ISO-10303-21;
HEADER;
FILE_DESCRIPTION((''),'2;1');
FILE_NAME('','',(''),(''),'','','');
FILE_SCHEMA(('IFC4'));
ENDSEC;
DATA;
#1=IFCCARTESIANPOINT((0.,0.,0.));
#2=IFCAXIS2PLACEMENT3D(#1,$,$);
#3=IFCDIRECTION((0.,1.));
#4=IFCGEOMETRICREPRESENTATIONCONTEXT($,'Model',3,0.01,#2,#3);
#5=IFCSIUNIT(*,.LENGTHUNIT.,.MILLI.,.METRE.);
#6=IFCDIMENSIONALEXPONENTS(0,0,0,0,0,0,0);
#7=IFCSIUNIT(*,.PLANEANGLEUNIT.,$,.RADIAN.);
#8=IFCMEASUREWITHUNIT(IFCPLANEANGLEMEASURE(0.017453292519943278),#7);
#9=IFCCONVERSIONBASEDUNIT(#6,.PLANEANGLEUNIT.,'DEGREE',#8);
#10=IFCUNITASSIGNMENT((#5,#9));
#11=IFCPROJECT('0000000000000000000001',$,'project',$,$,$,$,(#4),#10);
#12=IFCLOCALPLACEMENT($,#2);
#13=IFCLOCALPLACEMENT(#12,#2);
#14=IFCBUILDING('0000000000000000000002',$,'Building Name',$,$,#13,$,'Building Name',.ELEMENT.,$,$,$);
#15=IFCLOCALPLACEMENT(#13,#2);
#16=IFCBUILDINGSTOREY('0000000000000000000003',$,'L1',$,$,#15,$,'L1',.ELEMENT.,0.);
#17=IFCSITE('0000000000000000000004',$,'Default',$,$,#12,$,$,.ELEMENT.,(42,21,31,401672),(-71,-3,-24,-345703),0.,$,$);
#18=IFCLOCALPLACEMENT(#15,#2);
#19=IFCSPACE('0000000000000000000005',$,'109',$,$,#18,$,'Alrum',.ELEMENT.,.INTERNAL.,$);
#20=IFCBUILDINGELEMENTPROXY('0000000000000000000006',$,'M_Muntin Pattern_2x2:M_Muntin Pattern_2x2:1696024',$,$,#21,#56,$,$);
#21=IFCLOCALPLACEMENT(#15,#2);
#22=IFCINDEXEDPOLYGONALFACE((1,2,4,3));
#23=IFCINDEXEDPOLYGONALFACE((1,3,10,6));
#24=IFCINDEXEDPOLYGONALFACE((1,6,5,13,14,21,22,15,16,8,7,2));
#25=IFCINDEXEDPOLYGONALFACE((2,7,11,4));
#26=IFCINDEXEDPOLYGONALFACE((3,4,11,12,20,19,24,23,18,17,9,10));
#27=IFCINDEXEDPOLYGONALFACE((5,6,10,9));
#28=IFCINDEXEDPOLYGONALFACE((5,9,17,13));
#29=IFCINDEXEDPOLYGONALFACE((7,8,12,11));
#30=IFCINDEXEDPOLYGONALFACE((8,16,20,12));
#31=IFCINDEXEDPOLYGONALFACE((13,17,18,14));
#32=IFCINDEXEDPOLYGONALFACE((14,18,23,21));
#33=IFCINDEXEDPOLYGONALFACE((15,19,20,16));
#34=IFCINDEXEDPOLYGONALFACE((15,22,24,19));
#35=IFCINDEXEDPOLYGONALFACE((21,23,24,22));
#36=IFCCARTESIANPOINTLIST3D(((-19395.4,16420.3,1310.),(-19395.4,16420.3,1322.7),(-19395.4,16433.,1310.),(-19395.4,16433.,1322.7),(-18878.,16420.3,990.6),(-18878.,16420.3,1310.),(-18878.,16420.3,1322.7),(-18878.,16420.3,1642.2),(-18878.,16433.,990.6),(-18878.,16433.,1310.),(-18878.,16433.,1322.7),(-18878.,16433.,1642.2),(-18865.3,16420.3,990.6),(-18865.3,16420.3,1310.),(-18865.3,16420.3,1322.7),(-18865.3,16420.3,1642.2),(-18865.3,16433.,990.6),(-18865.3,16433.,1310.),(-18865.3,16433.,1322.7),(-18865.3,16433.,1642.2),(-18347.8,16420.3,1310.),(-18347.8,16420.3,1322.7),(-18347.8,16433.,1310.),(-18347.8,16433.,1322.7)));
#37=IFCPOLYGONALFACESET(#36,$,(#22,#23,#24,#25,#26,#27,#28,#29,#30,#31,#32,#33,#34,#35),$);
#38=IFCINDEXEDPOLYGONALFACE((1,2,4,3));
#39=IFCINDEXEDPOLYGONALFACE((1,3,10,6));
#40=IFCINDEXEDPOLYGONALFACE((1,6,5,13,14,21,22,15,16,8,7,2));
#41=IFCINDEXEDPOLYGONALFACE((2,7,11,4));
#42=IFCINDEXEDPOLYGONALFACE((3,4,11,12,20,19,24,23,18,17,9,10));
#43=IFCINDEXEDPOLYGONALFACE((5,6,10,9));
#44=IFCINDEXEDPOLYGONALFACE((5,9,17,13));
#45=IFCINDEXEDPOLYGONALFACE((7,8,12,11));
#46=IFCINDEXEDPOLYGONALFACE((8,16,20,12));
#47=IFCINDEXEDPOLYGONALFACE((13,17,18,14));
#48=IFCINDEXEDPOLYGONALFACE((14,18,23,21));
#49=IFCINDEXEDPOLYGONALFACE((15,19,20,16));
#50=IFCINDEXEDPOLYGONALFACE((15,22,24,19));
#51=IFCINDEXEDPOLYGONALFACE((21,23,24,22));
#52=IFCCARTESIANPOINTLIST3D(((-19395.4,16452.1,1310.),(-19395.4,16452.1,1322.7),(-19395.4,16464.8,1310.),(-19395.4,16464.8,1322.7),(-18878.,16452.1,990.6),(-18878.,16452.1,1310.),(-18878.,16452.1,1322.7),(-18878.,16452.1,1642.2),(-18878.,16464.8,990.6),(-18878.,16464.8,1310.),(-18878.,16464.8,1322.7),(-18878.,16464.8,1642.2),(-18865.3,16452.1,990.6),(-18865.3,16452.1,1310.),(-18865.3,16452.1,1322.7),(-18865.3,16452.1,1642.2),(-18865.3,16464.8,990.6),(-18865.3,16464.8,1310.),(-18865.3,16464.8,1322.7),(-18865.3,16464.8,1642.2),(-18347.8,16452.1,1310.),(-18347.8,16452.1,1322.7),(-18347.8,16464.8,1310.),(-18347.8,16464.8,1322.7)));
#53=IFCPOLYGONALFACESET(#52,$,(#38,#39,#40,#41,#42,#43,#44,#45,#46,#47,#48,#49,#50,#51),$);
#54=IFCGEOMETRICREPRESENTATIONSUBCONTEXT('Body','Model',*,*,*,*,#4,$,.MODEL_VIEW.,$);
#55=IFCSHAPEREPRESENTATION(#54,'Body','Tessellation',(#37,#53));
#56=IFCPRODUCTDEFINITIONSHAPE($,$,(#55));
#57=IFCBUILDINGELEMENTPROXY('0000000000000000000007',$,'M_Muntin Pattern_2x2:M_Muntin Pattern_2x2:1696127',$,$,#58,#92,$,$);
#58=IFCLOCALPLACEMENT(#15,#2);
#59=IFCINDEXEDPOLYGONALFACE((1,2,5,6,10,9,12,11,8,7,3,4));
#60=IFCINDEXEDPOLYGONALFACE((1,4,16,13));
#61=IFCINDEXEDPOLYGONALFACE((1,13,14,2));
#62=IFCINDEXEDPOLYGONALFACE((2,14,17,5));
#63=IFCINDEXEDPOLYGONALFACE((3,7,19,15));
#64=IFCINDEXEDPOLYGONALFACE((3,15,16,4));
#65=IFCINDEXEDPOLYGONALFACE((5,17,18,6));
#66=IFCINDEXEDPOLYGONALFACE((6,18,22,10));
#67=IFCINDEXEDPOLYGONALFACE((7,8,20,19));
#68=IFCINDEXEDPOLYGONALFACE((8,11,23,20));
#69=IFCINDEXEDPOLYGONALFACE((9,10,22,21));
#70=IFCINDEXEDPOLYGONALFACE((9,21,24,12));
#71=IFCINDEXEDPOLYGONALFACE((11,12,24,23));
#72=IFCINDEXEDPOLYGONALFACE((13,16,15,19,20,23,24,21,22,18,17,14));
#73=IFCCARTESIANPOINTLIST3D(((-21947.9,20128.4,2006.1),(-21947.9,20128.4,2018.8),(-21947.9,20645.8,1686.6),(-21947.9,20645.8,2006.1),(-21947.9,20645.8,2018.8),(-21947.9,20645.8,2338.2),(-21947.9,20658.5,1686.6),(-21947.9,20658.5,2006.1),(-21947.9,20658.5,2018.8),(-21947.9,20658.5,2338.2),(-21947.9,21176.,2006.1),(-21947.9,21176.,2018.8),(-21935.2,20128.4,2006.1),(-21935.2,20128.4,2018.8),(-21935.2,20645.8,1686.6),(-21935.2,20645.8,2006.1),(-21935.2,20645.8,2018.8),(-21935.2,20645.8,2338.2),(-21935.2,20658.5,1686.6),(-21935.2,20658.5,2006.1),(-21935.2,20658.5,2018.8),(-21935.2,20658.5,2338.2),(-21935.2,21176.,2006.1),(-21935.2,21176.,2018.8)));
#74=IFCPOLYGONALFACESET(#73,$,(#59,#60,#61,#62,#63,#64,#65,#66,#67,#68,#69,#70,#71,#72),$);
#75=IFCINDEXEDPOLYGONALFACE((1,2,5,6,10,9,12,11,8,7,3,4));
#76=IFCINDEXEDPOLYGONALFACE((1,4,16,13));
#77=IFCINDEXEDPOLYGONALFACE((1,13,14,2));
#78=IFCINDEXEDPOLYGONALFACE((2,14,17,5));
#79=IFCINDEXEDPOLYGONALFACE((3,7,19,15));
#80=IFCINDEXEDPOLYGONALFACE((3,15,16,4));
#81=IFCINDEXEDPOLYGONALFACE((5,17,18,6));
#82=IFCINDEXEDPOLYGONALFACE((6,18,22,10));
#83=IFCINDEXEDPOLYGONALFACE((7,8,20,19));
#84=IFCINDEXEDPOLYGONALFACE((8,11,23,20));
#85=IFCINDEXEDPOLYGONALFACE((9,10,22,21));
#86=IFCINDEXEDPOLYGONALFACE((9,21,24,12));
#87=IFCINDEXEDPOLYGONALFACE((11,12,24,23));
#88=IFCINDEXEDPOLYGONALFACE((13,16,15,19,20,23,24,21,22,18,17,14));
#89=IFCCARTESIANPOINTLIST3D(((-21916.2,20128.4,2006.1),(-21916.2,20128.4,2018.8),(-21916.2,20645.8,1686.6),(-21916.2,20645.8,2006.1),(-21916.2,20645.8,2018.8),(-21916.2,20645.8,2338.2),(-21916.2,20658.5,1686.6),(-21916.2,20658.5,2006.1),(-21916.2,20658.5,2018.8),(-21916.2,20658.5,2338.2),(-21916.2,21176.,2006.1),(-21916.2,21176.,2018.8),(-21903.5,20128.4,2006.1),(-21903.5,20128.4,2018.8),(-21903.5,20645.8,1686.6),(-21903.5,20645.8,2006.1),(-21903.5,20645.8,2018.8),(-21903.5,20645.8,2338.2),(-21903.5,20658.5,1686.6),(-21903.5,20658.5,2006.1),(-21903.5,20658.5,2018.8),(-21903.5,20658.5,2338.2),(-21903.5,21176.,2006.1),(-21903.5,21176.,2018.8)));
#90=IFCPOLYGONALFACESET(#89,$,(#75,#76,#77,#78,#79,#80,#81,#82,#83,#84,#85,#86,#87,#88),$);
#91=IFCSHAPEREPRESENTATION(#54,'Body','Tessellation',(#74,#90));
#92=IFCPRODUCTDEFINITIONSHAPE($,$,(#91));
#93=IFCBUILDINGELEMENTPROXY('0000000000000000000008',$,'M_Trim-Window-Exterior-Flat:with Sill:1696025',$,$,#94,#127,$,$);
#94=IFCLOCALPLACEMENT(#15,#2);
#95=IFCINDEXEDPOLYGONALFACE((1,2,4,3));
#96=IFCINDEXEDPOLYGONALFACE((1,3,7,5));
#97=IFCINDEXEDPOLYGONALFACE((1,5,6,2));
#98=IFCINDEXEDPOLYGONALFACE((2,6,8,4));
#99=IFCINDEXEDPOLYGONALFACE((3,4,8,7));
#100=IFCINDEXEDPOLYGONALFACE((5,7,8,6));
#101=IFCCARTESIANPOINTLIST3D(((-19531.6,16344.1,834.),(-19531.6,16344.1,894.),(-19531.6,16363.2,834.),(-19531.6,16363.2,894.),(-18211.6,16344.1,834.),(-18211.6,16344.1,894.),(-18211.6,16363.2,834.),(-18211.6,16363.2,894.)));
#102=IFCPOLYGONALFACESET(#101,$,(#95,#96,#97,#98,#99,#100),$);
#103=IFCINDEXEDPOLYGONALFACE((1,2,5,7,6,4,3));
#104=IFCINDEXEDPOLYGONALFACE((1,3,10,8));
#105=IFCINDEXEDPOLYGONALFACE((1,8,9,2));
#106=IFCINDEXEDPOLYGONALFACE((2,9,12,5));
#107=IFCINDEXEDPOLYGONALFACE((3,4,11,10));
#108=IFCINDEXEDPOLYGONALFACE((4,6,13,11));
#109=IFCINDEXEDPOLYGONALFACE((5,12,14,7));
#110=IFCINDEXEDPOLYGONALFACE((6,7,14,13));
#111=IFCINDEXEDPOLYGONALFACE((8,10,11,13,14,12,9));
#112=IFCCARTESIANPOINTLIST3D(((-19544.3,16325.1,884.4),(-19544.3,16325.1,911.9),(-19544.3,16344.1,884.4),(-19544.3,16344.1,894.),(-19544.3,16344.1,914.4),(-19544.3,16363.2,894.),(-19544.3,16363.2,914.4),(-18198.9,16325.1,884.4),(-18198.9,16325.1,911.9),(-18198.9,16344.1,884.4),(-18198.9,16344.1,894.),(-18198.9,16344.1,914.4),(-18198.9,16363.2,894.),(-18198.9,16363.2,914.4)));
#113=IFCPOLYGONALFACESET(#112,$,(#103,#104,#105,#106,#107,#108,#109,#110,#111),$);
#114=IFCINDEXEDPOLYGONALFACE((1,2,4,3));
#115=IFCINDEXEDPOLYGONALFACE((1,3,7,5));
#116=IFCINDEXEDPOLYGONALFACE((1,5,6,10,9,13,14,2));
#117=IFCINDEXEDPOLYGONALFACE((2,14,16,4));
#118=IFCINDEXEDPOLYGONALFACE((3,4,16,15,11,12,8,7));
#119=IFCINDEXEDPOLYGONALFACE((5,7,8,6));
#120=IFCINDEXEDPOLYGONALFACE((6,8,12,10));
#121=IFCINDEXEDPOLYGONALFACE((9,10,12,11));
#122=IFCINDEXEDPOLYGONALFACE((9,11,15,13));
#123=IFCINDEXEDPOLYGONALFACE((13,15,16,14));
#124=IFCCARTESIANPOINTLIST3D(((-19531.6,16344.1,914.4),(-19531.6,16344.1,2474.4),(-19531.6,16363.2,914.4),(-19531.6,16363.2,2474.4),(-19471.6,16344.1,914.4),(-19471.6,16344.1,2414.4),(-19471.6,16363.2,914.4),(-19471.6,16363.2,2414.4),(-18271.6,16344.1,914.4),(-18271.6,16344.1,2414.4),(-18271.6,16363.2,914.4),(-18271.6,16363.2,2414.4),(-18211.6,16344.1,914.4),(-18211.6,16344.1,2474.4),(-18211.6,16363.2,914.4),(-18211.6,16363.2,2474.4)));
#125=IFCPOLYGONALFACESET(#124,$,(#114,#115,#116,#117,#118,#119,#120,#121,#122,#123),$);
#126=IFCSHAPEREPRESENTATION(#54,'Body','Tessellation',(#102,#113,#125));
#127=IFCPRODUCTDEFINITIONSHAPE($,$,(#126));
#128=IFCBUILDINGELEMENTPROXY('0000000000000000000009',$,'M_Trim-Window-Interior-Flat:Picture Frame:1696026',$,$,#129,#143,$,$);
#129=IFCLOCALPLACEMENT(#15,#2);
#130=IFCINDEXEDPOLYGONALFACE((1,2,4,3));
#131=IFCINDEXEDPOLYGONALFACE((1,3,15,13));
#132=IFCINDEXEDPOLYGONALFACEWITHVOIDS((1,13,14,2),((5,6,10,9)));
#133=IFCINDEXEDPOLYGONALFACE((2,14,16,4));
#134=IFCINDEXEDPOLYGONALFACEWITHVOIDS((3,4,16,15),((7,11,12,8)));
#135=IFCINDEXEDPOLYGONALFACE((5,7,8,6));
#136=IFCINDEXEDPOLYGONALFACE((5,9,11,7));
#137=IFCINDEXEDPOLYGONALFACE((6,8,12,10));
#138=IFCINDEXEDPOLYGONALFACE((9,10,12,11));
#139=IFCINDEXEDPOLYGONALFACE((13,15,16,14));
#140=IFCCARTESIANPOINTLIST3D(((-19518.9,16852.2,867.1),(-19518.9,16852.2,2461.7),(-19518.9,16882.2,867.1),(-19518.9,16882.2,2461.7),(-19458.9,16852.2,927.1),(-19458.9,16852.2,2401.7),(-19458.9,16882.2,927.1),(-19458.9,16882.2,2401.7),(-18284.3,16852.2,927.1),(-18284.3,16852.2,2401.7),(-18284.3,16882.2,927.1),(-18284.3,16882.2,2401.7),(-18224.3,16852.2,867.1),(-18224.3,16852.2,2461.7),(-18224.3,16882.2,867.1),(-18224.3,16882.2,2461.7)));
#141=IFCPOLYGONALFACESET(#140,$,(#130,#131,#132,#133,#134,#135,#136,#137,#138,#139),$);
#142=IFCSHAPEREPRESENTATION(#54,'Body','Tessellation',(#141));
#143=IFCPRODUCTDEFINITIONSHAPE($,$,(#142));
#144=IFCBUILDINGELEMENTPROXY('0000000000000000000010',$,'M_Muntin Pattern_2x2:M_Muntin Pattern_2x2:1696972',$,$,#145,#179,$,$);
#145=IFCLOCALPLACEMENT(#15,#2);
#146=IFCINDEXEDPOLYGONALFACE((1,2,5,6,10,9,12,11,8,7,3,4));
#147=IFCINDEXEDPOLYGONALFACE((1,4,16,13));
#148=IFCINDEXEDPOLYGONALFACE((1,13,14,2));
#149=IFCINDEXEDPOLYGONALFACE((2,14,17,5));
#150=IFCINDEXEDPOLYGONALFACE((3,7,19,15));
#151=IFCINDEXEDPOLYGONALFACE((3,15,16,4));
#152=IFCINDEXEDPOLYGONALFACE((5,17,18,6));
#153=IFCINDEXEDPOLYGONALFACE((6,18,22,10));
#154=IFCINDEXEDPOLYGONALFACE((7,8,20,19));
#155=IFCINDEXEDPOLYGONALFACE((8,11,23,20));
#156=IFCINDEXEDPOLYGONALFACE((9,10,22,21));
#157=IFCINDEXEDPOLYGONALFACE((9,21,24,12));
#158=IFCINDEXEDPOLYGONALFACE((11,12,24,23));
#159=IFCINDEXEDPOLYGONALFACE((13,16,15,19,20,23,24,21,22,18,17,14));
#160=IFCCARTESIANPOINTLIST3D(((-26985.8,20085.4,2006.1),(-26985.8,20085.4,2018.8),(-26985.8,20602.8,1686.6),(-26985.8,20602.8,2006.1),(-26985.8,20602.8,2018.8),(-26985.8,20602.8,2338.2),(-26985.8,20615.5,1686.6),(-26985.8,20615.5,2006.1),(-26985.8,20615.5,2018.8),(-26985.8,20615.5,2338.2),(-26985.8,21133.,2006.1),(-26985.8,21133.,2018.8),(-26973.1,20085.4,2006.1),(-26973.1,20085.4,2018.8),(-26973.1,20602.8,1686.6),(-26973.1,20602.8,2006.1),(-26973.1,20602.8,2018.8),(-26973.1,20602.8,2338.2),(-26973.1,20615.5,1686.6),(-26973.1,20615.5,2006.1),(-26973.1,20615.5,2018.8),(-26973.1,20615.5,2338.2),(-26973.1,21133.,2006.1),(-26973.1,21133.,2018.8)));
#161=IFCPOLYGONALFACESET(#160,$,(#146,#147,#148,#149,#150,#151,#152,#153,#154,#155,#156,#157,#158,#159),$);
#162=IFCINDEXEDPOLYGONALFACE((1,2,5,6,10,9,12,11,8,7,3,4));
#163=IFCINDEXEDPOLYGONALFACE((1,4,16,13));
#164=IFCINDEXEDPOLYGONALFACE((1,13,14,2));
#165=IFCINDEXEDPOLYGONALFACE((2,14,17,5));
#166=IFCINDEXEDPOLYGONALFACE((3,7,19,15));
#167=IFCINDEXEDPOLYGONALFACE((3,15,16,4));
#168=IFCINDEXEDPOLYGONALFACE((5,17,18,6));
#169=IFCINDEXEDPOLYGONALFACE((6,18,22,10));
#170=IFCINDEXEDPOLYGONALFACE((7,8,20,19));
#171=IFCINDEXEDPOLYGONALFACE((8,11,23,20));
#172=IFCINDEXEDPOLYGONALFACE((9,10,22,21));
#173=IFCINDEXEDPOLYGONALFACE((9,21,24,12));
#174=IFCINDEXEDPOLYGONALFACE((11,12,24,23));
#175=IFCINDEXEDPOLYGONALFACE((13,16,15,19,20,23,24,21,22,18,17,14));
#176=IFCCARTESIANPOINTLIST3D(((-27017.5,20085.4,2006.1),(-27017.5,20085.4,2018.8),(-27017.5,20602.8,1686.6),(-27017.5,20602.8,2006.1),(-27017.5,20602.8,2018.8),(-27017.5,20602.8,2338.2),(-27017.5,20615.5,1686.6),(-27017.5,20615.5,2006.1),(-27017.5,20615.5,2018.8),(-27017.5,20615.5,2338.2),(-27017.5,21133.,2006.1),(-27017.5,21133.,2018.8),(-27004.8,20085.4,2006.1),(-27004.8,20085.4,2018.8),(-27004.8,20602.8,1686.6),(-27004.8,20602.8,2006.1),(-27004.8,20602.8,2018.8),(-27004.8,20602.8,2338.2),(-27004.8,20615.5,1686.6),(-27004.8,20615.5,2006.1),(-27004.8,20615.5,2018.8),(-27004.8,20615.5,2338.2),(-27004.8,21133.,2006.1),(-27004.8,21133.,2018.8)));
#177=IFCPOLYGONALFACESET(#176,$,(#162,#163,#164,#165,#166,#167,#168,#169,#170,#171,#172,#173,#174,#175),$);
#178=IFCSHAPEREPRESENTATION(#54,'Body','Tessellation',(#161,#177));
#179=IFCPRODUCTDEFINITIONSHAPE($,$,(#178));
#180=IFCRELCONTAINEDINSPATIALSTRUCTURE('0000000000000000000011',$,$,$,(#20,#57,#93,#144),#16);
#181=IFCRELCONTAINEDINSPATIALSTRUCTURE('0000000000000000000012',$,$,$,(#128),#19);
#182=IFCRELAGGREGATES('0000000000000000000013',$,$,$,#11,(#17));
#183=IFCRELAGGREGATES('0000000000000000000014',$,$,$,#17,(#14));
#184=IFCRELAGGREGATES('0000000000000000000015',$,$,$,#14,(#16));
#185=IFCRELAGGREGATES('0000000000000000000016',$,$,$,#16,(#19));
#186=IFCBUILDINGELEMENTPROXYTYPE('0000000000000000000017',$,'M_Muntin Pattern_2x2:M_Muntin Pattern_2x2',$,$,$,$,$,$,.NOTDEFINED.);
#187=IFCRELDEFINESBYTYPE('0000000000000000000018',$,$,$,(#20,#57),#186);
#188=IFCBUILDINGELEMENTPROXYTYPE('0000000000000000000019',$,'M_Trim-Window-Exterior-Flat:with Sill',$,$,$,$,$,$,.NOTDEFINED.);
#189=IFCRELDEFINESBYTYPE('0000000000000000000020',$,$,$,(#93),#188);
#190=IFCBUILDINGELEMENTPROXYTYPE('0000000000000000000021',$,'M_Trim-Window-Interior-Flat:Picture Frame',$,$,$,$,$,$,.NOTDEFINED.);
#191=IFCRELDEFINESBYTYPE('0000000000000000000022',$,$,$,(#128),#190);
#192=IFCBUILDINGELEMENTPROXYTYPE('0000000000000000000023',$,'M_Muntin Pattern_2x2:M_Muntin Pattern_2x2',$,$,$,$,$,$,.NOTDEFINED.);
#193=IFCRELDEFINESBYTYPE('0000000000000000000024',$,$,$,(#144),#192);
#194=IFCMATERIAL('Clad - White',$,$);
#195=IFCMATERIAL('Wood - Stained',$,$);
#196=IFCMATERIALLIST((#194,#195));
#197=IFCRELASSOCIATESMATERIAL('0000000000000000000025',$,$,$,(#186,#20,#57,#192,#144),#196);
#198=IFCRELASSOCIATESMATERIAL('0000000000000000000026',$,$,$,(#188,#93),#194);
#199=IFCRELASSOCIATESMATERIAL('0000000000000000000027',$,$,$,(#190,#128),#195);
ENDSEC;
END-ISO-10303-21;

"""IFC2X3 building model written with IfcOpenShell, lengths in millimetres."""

from ifc_helpers import new_model, entity, si_unit, converted_unit, direction, frame, frame_2d, origin, place, context, subcontext, project, spatial, polyline, rectangle, outline, extrude, source, transform, mapped, material, material_list, type_object, type_shapes, element, save


model = new_model("IFC2X3")

# Units and contexts
model_context = context("Model", 3, precision=0.01, world=origin(), true_north=direction((0.0, 1.0)))
body_context = subcontext(model_context, "Body", "Model", "MODEL_VIEW")
ifc_project = project(units=[si_unit("LENGTHUNIT", "METRE", prefix="MILLI"), converted_unit("PLANEANGLEUNIT", "DEGREE", entity("IfcPlaneAngleMeasure", 0.017453292519943278), si_unit("PLANEANGLEUNIT", "RADIAN"), dimensions=[0, 0, 0, 0, 0, 0, 0])], contexts=[model_context])

# Site, building, storey
site_placement = place(None, origin())
site = spatial("IfcSite", under=ifc_project, at=site_placement, Name="Default", CompositionType="ELEMENT", RefLatitude=(42, 21, 31, 401672), RefLongitude=(-71, -3, -24, -345703), RefElevation=0.0)
building_placement = place(site_placement, origin())
building = spatial("IfcBuilding", under=site, at=building_placement, Name="Building Name", LongName="Building Name", CompositionType="ELEMENT")
storey_placement = place(building_placement, origin())
storey = spatial("IfcBuildingStorey", under=building, at=storey_placement, Name="L1", LongName="L1", CompositionType="ELEMENT", Elevation=0.0)

# Shared definitions
ifc_material_1 = material(Name="Wood - Stained")

# Building element proxies
ifc_material_2 = material(Name="Clad - White")
ifc_material_list_1 = material_list([ifc_material_2, ifc_material_1])
building_element_proxy_type_1 = type_object("IfcBuildingElementProxyType", Name="M_Muntin Pattern_2x2:M_Muntin Pattern_2x2", PredefinedType="NOTDEFINED", material=ifc_material_list_1)
shared_shape_1 = source(origin(), body_context, "Body", "SweptSolid", [
    extrude(outline(polyline([(6.4, -6.4), (325.8, -6.4), (325.8, 6.3), (6.4, 6.3), (6.4, 523.8), (-6.3, 523.8), (-6.3, 6.3), (-325.8, 6.3), (-325.8, -6.4), (-6.3, -6.4), (-6.3, -523.8), (6.4, -523.8), (6.4, -6.4)])), frame((0.0, 9.5, 325.8), z_axis=(0.0, 1.0, 0.0), x_axis=(0.0, 0.0, 1.0)), (0.0, 0.0, 1.0), 12.7),
    extrude(outline(polyline([(6.4, -6.4), (325.8, -6.4), (325.8, 6.3), (6.4, 6.3), (6.4, 523.8), (-6.3, 523.8), (-6.3, 6.3), (-325.8, 6.3), (-325.8, -6.4), (-6.3, -6.4), (-6.3, -523.8), (6.4, -523.8), (6.4, -6.4)])), frame((0.0, -22.2, 325.8), z_axis=(0.0, 1.0, 0.0), x_axis=(0.0, 0.0, 1.0)), (0.0, 0.0, 1.0), 12.7),
])
type_shapes(building_element_proxy_type_1, [shared_shape_1])
for number, where, z_axis, x_axis, name in (
    (1, (-18871.6, 16442.5, 990.6), (0.0, 0.0, 1.0), (-1.0, 0.0, 0.0), "M_Muntin Pattern_2x2:M_Muntin Pattern_2x2:1696024"),
    (2, (-21925.7, 20652.2, 1686.6), (0.0, 0.0, 1.0), (0.0, 1.0, 0.0), "M_Muntin Pattern_2x2:M_Muntin Pattern_2x2:1696127"),
):
    element("IfcBuildingElementProxy", number, at=place(storey_placement, frame(where, z_axis=z_axis, x_axis=x_axis)), inside=storey, type_object=building_element_proxy_type_1, material=ifc_material_list_1, Name=name, context=body_context, shape_type="MappedRepresentation", body=[
        mapped(shared_shape_1, transform((0.0, 0.0, 0.0), scale=1.0)),
    ])
building_element_proxy_type_2 = type_object("IfcBuildingElementProxyType", Name="M_Trim-Window-Exterior-Flat:with Sill", PredefinedType="NOTDEFINED", material=ifc_material_2)
shared_shape_2 = source(origin(), body_context, "Body", "SweptSolid", [
    extrude(rectangle(XDim=1320.0, YDim=60.0, at=frame_2d((0.0, 0.0), x_axis=(1.0, 0.0))), frame((0.0, -1550.4, 0.0), z_axis=(0.0, 0.0, 1.0), x_axis=(-1.0, 0.0, 0.0)), (0.0, 0.0, 1.0), 19.0),
    extrude(outline(polyline([(-19.0, -15.2), (0.0, -15.2), (0.0, -5.7), (19.0, -5.7), (19.0, 14.8), (0.0, 14.8), (-19.0, 12.3), (-19.0, -15.2)])), frame((-672.7, -1514.8, 19.0), z_axis=(1.0, 0.0, 0.0), x_axis=(0.0, 0.0, -1.0)), (0.0, 0.0, 1.0), 1345.4),
    extrude(outline(polyline([(-795.0, -660.0), (765.0, -660.0), (765.0, -600.0), (-735.0, -600.0), (-735.0, 600.0), (765.0, 600.0), (765.0, 660.0), (-795.0, 660.0), (-795.0, -660.0)])), frame((0.0, -735.0, 0.0), z_axis=(0.0, 0.0, 1.0), x_axis=(0.0, -1.0, 0.0)), (0.0, 0.0, 1.0), 19.0),
])
type_shapes(building_element_proxy_type_2, [shared_shape_2])
proxy_1_placement = place(storey_placement, frame((-18871.6, 16363.2, 2414.4), z_axis=(0.0, -1.0, 0.0), x_axis=(1.0, 0.0, 0.0)))
element("IfcBuildingElementProxy", 3, at=proxy_1_placement, inside=storey, type_object=building_element_proxy_type_2, material=ifc_material_2, Name="M_Trim-Window-Exterior-Flat:with Sill:1696025", context=body_context, shape_type="MappedRepresentation", body=[
    mapped(shared_shape_2, transform((0.0, 0.0, 0.0), scale=1.0)),
])

# Shared definitions
space_placement = place(storey_placement, origin())
space = spatial("IfcSpace", under=storey, at=space_placement, Name="109", LongName="Alrum", CompositionType="ELEMENT", InteriorOrExteriorSpace="INTERNAL")

# Building element proxies
building_element_proxy_type_3 = type_object("IfcBuildingElementProxyType", Name="M_Trim-Window-Interior-Flat:Picture Frame", PredefinedType="NOTDEFINED", material=ifc_material_1)
shared_shape_3 = source(origin(), body_context, "Body", "SweptSolid", [
    extrude(outline(polyline([(-647.3, -797.3), (647.3, -797.3), (647.3, 797.3), (-647.3, 797.3), (-647.3, -797.3)]), holes=[polyline([(-587.3, -737.3), (-587.3, 737.3), (587.3, 737.3), (587.3, -737.3), (-587.3, -737.3)])]), frame((0.0, -750.0, 0.0), z_axis=(0.0, 0.0, 1.0), x_axis=(-1.0, 0.0, 0.0)), (0.0, 0.0, 1.0), 30.0),
])
type_shapes(building_element_proxy_type_3, [shared_shape_3])
proxy_2_placement = place(space_placement, frame((-18871.6, 16852.2, 2414.4), z_axis=(0.0, 1.0, 0.0), x_axis=(-1.0, 0.0, 0.0)))
element("IfcBuildingElementProxy", 4, at=proxy_2_placement, inside=space, type_object=building_element_proxy_type_3, material=ifc_material_1, Name="M_Trim-Window-Interior-Flat:Picture Frame:1696026", context=body_context, shape_type="MappedRepresentation", body=[
    mapped(shared_shape_3, transform((0.0, 0.0, 0.0), scale=1.0)),
])
building_element_proxy_type_4 = type_object("IfcBuildingElementProxyType", Name="M_Muntin Pattern_2x2:M_Muntin Pattern_2x2", PredefinedType="NOTDEFINED", material=ifc_material_list_1)
shared_shape_4 = source(origin(), body_context, "Body", "SweptSolid", [
    extrude(outline(polyline([(6.4, -6.4), (325.8, -6.4), (325.8, 6.3), (6.4, 6.3), (6.4, 523.8), (-6.3, 523.8), (-6.3, 6.3), (-325.8, 6.3), (-325.8, -6.4), (-6.3, -6.4), (-6.3, -523.8), (6.4, -523.8), (6.4, -6.4)])), frame((0.0, -22.2, 325.8), z_axis=(0.0, 1.0, 0.0), x_axis=(0.0, 0.0, 1.0)), (0.0, 0.0, 1.0), 12.7),
    extrude(outline(polyline([(6.4, -6.4), (325.8, -6.4), (325.8, 6.3), (6.4, 6.3), (6.4, 523.8), (-6.3, 523.8), (-6.3, 6.3), (-325.8, 6.3), (-325.8, -6.4), (-6.3, -6.4), (-6.3, -523.8), (6.4, -523.8), (6.4, -6.4)])), frame((0.0, 9.5, 325.8), z_axis=(0.0, 1.0, 0.0), x_axis=(0.0, 0.0, 1.0)), (0.0, 0.0, 1.0), 12.7),
])
type_shapes(building_element_proxy_type_4, [shared_shape_4])
proxy_3_placement = place(storey_placement, frame((-26995.3, 20609.2, 1686.6), z_axis=(0.0, 0.0, 1.0), x_axis=(0.0, 1.0, 0.0)))
element("IfcBuildingElementProxy", 5, at=proxy_3_placement, inside=storey, type_object=building_element_proxy_type_4, material=ifc_material_list_1, Name="M_Muntin Pattern_2x2:M_Muntin Pattern_2x2:1696972", context=body_context, shape_type="MappedRepresentation", body=[
    mapped(shared_shape_4, transform((0.0, 0.0, 0.0), scale=1.0)),
])

save(model, "model.ifc")
